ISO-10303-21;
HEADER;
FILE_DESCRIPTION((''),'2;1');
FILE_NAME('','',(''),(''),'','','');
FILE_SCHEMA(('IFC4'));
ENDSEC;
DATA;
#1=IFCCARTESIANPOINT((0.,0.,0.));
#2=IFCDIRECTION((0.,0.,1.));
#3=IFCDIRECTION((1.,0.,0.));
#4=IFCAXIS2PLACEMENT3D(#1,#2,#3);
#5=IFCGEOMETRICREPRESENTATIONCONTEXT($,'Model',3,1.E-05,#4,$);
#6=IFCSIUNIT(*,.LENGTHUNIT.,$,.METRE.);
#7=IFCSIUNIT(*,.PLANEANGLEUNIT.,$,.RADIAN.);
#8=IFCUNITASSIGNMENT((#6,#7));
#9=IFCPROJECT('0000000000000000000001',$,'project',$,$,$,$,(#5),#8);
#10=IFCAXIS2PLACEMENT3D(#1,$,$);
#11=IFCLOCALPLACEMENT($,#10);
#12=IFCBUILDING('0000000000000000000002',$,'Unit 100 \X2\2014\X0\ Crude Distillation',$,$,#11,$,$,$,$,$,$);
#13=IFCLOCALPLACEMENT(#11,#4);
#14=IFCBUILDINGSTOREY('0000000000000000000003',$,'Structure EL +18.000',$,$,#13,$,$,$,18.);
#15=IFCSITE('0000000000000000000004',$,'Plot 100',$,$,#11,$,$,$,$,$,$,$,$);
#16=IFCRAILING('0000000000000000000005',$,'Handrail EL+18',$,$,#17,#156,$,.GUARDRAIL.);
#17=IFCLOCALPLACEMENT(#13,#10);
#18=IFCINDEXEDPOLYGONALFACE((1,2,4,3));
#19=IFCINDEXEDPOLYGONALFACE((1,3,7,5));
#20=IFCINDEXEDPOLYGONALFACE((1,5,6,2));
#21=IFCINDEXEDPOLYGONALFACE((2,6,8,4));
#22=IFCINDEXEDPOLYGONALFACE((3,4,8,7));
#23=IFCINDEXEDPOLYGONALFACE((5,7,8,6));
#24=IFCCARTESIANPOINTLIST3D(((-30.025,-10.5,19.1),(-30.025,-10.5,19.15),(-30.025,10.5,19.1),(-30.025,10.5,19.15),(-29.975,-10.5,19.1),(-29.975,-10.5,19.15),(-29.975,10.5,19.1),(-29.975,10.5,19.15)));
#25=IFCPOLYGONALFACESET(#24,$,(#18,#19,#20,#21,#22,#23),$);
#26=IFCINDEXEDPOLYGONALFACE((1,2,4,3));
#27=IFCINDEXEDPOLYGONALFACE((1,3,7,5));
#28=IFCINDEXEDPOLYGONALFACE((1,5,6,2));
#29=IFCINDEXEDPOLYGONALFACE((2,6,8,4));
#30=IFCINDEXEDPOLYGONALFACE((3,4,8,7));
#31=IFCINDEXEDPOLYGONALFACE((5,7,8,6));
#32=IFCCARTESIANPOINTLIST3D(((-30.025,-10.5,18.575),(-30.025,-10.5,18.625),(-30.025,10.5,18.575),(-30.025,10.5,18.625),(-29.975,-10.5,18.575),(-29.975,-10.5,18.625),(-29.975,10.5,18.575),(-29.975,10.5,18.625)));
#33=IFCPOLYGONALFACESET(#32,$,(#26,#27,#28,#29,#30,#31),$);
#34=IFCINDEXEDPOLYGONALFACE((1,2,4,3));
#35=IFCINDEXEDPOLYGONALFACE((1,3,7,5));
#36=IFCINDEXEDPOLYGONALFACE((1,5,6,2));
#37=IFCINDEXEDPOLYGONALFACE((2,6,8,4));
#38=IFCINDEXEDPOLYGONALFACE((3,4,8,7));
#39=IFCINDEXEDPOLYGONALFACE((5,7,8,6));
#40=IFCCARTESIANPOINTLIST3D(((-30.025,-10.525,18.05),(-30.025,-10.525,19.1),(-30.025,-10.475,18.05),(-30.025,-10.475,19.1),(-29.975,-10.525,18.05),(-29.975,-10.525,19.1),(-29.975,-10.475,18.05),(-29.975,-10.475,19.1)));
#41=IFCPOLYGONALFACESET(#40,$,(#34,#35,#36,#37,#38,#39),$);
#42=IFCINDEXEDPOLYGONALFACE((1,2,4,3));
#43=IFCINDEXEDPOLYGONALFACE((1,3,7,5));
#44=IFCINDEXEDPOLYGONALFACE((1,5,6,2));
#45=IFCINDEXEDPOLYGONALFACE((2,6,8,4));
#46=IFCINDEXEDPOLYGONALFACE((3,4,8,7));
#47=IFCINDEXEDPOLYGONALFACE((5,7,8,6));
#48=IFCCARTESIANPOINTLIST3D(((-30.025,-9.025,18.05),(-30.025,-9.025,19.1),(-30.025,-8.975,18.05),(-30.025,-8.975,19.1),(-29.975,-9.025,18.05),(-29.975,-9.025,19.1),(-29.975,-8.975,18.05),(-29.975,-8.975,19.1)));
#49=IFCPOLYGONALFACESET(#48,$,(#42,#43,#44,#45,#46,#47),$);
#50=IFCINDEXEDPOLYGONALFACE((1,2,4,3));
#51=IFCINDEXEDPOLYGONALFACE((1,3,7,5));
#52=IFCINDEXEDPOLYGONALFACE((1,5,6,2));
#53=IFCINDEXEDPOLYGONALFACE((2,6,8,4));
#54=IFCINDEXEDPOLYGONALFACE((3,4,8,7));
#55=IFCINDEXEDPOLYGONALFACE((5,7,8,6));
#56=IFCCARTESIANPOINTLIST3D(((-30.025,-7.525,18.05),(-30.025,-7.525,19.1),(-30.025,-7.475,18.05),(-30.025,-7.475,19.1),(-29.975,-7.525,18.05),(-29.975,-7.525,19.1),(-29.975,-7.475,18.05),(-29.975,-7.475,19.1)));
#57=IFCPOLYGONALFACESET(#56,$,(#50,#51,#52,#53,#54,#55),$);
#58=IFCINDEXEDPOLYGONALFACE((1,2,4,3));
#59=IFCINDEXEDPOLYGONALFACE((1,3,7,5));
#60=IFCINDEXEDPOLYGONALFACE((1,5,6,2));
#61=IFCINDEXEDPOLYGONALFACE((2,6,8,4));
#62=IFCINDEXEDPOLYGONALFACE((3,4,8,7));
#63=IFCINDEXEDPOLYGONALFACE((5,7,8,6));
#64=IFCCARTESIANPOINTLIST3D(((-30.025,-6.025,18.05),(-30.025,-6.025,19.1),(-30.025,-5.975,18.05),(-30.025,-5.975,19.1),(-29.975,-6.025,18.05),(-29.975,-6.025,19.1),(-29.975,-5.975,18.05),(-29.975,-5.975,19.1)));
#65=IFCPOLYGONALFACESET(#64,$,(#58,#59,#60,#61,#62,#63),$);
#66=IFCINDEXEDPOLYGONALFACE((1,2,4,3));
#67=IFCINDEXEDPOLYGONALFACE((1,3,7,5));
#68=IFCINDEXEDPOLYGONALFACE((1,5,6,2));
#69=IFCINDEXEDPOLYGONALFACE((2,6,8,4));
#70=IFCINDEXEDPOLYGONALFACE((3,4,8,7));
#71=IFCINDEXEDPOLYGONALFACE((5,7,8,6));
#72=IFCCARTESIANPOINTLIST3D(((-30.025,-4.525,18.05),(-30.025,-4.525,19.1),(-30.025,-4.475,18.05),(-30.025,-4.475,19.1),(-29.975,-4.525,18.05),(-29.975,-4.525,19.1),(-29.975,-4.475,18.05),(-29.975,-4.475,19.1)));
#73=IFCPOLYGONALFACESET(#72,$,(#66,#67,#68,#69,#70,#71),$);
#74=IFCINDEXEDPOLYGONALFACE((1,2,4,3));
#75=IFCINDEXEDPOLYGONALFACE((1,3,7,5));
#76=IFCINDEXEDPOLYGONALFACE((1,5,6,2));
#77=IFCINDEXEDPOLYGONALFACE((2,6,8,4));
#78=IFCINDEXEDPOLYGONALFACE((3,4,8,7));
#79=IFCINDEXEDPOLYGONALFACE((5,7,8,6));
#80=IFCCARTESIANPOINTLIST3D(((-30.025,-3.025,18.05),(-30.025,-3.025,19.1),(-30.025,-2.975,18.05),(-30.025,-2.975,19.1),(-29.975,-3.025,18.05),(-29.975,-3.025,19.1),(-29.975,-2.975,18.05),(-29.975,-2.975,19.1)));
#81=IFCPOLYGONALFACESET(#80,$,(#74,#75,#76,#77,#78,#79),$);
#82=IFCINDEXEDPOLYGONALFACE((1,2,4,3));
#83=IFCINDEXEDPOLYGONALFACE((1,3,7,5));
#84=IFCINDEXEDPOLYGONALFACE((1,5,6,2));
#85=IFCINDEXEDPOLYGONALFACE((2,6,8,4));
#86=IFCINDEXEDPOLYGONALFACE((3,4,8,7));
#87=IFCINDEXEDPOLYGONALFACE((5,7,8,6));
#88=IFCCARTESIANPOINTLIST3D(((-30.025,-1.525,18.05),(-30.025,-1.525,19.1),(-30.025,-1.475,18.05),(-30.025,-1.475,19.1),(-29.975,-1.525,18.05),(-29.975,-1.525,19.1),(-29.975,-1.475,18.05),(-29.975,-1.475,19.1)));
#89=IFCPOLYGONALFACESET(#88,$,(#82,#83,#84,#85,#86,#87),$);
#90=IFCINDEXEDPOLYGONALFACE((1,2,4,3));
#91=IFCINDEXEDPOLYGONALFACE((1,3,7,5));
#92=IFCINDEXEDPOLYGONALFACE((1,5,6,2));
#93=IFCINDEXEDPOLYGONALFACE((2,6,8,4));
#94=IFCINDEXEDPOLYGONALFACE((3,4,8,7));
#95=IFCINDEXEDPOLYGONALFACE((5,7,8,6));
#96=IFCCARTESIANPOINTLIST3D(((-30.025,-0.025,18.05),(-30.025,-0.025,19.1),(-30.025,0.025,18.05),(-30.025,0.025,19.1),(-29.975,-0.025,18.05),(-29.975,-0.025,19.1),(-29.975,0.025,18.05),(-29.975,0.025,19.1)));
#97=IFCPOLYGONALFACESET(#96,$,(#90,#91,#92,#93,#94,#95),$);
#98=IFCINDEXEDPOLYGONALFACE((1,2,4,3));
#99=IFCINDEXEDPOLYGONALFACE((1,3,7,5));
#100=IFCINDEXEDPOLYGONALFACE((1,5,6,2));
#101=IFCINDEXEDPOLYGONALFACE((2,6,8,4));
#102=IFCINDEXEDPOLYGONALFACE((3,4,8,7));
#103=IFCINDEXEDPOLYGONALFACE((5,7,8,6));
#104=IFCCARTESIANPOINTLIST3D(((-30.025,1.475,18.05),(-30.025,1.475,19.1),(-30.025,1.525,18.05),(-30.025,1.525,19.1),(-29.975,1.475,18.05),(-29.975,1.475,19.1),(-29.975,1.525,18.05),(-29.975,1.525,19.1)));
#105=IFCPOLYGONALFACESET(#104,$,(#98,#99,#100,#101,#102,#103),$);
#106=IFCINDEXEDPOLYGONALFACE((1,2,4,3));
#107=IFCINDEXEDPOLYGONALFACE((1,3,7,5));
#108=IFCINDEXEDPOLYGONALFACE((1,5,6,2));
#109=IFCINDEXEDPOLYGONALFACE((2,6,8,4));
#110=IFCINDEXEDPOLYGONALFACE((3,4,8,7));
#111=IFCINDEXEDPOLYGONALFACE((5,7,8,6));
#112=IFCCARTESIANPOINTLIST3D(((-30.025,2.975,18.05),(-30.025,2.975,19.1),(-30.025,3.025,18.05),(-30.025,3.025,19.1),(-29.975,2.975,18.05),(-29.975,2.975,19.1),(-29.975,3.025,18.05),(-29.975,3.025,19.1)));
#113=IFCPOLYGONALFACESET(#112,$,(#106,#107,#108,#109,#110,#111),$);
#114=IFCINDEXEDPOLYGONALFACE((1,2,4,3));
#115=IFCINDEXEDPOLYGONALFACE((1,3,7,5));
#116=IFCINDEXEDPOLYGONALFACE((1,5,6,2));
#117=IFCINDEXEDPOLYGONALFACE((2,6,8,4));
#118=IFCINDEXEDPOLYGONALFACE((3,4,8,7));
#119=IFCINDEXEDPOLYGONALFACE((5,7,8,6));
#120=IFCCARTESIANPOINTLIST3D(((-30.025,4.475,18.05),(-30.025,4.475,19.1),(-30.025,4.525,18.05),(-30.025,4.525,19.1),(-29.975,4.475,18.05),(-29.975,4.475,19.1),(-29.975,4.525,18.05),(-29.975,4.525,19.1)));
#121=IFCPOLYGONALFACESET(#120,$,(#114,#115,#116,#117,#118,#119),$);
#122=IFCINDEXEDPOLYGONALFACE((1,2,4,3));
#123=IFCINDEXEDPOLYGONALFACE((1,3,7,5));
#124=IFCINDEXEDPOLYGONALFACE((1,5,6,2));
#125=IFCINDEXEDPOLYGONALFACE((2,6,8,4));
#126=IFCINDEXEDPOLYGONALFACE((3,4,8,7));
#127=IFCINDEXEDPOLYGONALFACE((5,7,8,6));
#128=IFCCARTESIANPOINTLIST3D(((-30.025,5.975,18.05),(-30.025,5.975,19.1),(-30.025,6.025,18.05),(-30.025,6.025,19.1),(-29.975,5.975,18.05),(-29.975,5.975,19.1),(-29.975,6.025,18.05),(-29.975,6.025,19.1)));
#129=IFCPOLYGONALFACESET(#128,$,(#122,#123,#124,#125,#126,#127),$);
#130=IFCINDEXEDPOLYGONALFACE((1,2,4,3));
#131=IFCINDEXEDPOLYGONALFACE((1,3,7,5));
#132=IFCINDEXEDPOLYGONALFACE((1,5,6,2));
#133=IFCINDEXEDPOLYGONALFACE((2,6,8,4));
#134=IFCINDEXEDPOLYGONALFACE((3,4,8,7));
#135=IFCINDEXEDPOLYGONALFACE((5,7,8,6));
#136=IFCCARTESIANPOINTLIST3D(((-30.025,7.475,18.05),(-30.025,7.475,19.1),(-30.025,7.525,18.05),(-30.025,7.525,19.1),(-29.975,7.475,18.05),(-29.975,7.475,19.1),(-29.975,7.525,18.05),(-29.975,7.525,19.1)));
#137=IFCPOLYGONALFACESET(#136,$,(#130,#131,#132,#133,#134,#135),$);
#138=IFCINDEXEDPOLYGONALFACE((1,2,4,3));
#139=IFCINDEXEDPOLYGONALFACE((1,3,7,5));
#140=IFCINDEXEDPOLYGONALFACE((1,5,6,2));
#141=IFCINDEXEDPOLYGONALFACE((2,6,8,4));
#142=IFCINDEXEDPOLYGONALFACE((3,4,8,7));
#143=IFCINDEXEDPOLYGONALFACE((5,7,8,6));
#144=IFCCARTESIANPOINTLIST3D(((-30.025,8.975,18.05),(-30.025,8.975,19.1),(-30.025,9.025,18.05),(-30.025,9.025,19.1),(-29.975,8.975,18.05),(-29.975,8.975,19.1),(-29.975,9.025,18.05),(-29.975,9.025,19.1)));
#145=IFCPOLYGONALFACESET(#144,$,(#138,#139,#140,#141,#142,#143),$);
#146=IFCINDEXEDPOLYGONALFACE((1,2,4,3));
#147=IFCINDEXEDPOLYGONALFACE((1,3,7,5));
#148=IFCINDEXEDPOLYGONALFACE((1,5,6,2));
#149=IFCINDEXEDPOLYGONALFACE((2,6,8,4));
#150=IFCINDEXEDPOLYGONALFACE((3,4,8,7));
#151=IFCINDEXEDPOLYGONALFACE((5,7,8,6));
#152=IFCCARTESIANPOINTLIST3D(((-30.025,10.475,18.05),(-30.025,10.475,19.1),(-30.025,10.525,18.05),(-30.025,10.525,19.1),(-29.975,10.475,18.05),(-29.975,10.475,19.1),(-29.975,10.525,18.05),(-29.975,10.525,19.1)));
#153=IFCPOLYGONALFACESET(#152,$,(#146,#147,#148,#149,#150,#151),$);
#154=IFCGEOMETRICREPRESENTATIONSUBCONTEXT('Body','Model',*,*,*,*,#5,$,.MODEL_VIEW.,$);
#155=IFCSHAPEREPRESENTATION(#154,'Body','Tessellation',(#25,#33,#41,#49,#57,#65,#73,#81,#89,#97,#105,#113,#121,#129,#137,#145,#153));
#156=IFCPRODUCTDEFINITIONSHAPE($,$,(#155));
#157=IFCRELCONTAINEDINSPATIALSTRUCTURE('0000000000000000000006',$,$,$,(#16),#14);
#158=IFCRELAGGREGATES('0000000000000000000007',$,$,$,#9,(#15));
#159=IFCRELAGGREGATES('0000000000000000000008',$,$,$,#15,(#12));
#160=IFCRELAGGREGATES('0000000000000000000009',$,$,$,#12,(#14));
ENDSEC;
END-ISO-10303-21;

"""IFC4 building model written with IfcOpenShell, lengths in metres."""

from ifc_helpers import new_model, si_unit, frame, origin, origin_with_axes, origin_2d, place, context, subcontext, project, spatial, rectangle, extrude, element, save


model = new_model("IFC4")

# Units and contexts
model_context = context("Model", 3, precision=1e-05, world=origin_with_axes())
body_context = subcontext(model_context, "Body", "Model", "MODEL_VIEW")
ifc_project = project(units=[si_unit("LENGTHUNIT", "METRE"), si_unit("PLANEANGLEUNIT", "RADIAN")], contexts=[model_context])

# Site, building, storey
placement = place(None, origin())
site = spatial("IfcSite", under=ifc_project, at=placement, Name="Plot 100")
building = spatial("IfcBuilding", under=site, at=placement, Name="Unit 100 — Crude Distillation")
storey_placement = place(placement, origin_with_axes())
storey = spatial("IfcBuildingStorey", under=building, at=storey_placement, Name="Structure EL +18.000", Elevation=18.0)

# Railing
railing_1_placement = place(storey_placement, origin_with_axes())
element("IfcRailing", 1, at=railing_1_placement, inside=storey, Name="Handrail EL+18", PredefinedType="GUARDRAIL", context=body_context, shape_type="SweptSolid", body=[
    extrude(rectangle(XDim=0.05, YDim=0.05, at=origin_2d()), frame((-30.0, -10.5, 19.125), z_axis=(0.0, 1.0, 0.0), x_axis=(-1.0, 0.0, 0.0)), (0.0, 0.0, 1.0), 21.0),
    extrude(rectangle(XDim=0.05, YDim=0.05, at=origin_2d()), frame((-30.0, -10.5, 18.6), z_axis=(0.0, 1.0, 0.0), x_axis=(-1.0, 0.0, 0.0)), (0.0, 0.0, 1.0), 21.0),
    extrude(rectangle(XDim=0.05, YDim=0.05, at=origin_2d()), frame((-30.0, -10.5, 18.05), z_axis=(0.0, 0.0, 1.0), x_axis=(1.0, 0.0, 0.0)), (0.0, 0.0, 1.0), 1.05),
    extrude(rectangle(XDim=0.05, YDim=0.05, at=origin_2d()), frame((-30.0, -9.0, 18.05), z_axis=(0.0, 0.0, 1.0), x_axis=(1.0, 0.0, 0.0)), (0.0, 0.0, 1.0), 1.05),
    extrude(rectangle(XDim=0.05, YDim=0.05, at=origin_2d()), frame((-30.0, -7.5, 18.05), z_axis=(0.0, 0.0, 1.0), x_axis=(1.0, 0.0, 0.0)), (0.0, 0.0, 1.0), 1.05),
    extrude(rectangle(XDim=0.05, YDim=0.05, at=origin_2d()), frame((-30.0, -6.0, 18.05), z_axis=(0.0, 0.0, 1.0), x_axis=(1.0, 0.0, 0.0)), (0.0, 0.0, 1.0), 1.05),
    extrude(rectangle(XDim=0.05, YDim=0.05, at=origin_2d()), frame((-30.0, -4.5, 18.05), z_axis=(0.0, 0.0, 1.0), x_axis=(1.0, 0.0, 0.0)), (0.0, 0.0, 1.0), 1.05),
    extrude(rectangle(XDim=0.05, YDim=0.05, at=origin_2d()), frame((-30.0, -3.0, 18.05), z_axis=(0.0, 0.0, 1.0), x_axis=(1.0, 0.0, 0.0)), (0.0, 0.0, 1.0), 1.05),
    extrude(rectangle(XDim=0.05, YDim=0.05, at=origin_2d()), frame((-30.0, -1.5, 18.05), z_axis=(0.0, 0.0, 1.0), x_axis=(1.0, 0.0, 0.0)), (0.0, 0.0, 1.0), 1.05),
    extrude(rectangle(XDim=0.05, YDim=0.05, at=origin_2d()), frame((-30.0, 0.0, 18.05), z_axis=(0.0, 0.0, 1.0), x_axis=(1.0, 0.0, 0.0)), (0.0, 0.0, 1.0), 1.05),
    extrude(rectangle(XDim=0.05, YDim=0.05, at=origin_2d()), frame((-30.0, 1.5, 18.05), z_axis=(0.0, 0.0, 1.0), x_axis=(1.0, 0.0, 0.0)), (0.0, 0.0, 1.0), 1.05),
    extrude(rectangle(XDim=0.05, YDim=0.05, at=origin_2d()), frame((-30.0, 3.0, 18.05), z_axis=(0.0, 0.0, 1.0), x_axis=(1.0, 0.0, 0.0)), (0.0, 0.0, 1.0), 1.05),
    extrude(rectangle(XDim=0.05, YDim=0.05, at=origin_2d()), frame((-30.0, 4.5, 18.05), z_axis=(0.0, 0.0, 1.0), x_axis=(1.0, 0.0, 0.0)), (0.0, 0.0, 1.0), 1.05),
    extrude(rectangle(XDim=0.05, YDim=0.05, at=origin_2d()), frame((-30.0, 6.0, 18.05), z_axis=(0.0, 0.0, 1.0), x_axis=(1.0, 0.0, 0.0)), (0.0, 0.0, 1.0), 1.05),
    extrude(rectangle(XDim=0.05, YDim=0.05, at=origin_2d()), frame((-30.0, 7.5, 18.05), z_axis=(0.0, 0.0, 1.0), x_axis=(1.0, 0.0, 0.0)), (0.0, 0.0, 1.0), 1.05),
    extrude(rectangle(XDim=0.05, YDim=0.05, at=origin_2d()), frame((-30.0, 9.0, 18.05), z_axis=(0.0, 0.0, 1.0), x_axis=(1.0, 0.0, 0.0)), (0.0, 0.0, 1.0), 1.05),
    extrude(rectangle(XDim=0.05, YDim=0.05, at=origin_2d()), frame((-30.0, 10.5, 18.05), z_axis=(0.0, 0.0, 1.0), x_axis=(1.0, 0.0, 0.0)), (0.0, 0.0, 1.0), 1.05),
])

save(model, "model.ifc")
